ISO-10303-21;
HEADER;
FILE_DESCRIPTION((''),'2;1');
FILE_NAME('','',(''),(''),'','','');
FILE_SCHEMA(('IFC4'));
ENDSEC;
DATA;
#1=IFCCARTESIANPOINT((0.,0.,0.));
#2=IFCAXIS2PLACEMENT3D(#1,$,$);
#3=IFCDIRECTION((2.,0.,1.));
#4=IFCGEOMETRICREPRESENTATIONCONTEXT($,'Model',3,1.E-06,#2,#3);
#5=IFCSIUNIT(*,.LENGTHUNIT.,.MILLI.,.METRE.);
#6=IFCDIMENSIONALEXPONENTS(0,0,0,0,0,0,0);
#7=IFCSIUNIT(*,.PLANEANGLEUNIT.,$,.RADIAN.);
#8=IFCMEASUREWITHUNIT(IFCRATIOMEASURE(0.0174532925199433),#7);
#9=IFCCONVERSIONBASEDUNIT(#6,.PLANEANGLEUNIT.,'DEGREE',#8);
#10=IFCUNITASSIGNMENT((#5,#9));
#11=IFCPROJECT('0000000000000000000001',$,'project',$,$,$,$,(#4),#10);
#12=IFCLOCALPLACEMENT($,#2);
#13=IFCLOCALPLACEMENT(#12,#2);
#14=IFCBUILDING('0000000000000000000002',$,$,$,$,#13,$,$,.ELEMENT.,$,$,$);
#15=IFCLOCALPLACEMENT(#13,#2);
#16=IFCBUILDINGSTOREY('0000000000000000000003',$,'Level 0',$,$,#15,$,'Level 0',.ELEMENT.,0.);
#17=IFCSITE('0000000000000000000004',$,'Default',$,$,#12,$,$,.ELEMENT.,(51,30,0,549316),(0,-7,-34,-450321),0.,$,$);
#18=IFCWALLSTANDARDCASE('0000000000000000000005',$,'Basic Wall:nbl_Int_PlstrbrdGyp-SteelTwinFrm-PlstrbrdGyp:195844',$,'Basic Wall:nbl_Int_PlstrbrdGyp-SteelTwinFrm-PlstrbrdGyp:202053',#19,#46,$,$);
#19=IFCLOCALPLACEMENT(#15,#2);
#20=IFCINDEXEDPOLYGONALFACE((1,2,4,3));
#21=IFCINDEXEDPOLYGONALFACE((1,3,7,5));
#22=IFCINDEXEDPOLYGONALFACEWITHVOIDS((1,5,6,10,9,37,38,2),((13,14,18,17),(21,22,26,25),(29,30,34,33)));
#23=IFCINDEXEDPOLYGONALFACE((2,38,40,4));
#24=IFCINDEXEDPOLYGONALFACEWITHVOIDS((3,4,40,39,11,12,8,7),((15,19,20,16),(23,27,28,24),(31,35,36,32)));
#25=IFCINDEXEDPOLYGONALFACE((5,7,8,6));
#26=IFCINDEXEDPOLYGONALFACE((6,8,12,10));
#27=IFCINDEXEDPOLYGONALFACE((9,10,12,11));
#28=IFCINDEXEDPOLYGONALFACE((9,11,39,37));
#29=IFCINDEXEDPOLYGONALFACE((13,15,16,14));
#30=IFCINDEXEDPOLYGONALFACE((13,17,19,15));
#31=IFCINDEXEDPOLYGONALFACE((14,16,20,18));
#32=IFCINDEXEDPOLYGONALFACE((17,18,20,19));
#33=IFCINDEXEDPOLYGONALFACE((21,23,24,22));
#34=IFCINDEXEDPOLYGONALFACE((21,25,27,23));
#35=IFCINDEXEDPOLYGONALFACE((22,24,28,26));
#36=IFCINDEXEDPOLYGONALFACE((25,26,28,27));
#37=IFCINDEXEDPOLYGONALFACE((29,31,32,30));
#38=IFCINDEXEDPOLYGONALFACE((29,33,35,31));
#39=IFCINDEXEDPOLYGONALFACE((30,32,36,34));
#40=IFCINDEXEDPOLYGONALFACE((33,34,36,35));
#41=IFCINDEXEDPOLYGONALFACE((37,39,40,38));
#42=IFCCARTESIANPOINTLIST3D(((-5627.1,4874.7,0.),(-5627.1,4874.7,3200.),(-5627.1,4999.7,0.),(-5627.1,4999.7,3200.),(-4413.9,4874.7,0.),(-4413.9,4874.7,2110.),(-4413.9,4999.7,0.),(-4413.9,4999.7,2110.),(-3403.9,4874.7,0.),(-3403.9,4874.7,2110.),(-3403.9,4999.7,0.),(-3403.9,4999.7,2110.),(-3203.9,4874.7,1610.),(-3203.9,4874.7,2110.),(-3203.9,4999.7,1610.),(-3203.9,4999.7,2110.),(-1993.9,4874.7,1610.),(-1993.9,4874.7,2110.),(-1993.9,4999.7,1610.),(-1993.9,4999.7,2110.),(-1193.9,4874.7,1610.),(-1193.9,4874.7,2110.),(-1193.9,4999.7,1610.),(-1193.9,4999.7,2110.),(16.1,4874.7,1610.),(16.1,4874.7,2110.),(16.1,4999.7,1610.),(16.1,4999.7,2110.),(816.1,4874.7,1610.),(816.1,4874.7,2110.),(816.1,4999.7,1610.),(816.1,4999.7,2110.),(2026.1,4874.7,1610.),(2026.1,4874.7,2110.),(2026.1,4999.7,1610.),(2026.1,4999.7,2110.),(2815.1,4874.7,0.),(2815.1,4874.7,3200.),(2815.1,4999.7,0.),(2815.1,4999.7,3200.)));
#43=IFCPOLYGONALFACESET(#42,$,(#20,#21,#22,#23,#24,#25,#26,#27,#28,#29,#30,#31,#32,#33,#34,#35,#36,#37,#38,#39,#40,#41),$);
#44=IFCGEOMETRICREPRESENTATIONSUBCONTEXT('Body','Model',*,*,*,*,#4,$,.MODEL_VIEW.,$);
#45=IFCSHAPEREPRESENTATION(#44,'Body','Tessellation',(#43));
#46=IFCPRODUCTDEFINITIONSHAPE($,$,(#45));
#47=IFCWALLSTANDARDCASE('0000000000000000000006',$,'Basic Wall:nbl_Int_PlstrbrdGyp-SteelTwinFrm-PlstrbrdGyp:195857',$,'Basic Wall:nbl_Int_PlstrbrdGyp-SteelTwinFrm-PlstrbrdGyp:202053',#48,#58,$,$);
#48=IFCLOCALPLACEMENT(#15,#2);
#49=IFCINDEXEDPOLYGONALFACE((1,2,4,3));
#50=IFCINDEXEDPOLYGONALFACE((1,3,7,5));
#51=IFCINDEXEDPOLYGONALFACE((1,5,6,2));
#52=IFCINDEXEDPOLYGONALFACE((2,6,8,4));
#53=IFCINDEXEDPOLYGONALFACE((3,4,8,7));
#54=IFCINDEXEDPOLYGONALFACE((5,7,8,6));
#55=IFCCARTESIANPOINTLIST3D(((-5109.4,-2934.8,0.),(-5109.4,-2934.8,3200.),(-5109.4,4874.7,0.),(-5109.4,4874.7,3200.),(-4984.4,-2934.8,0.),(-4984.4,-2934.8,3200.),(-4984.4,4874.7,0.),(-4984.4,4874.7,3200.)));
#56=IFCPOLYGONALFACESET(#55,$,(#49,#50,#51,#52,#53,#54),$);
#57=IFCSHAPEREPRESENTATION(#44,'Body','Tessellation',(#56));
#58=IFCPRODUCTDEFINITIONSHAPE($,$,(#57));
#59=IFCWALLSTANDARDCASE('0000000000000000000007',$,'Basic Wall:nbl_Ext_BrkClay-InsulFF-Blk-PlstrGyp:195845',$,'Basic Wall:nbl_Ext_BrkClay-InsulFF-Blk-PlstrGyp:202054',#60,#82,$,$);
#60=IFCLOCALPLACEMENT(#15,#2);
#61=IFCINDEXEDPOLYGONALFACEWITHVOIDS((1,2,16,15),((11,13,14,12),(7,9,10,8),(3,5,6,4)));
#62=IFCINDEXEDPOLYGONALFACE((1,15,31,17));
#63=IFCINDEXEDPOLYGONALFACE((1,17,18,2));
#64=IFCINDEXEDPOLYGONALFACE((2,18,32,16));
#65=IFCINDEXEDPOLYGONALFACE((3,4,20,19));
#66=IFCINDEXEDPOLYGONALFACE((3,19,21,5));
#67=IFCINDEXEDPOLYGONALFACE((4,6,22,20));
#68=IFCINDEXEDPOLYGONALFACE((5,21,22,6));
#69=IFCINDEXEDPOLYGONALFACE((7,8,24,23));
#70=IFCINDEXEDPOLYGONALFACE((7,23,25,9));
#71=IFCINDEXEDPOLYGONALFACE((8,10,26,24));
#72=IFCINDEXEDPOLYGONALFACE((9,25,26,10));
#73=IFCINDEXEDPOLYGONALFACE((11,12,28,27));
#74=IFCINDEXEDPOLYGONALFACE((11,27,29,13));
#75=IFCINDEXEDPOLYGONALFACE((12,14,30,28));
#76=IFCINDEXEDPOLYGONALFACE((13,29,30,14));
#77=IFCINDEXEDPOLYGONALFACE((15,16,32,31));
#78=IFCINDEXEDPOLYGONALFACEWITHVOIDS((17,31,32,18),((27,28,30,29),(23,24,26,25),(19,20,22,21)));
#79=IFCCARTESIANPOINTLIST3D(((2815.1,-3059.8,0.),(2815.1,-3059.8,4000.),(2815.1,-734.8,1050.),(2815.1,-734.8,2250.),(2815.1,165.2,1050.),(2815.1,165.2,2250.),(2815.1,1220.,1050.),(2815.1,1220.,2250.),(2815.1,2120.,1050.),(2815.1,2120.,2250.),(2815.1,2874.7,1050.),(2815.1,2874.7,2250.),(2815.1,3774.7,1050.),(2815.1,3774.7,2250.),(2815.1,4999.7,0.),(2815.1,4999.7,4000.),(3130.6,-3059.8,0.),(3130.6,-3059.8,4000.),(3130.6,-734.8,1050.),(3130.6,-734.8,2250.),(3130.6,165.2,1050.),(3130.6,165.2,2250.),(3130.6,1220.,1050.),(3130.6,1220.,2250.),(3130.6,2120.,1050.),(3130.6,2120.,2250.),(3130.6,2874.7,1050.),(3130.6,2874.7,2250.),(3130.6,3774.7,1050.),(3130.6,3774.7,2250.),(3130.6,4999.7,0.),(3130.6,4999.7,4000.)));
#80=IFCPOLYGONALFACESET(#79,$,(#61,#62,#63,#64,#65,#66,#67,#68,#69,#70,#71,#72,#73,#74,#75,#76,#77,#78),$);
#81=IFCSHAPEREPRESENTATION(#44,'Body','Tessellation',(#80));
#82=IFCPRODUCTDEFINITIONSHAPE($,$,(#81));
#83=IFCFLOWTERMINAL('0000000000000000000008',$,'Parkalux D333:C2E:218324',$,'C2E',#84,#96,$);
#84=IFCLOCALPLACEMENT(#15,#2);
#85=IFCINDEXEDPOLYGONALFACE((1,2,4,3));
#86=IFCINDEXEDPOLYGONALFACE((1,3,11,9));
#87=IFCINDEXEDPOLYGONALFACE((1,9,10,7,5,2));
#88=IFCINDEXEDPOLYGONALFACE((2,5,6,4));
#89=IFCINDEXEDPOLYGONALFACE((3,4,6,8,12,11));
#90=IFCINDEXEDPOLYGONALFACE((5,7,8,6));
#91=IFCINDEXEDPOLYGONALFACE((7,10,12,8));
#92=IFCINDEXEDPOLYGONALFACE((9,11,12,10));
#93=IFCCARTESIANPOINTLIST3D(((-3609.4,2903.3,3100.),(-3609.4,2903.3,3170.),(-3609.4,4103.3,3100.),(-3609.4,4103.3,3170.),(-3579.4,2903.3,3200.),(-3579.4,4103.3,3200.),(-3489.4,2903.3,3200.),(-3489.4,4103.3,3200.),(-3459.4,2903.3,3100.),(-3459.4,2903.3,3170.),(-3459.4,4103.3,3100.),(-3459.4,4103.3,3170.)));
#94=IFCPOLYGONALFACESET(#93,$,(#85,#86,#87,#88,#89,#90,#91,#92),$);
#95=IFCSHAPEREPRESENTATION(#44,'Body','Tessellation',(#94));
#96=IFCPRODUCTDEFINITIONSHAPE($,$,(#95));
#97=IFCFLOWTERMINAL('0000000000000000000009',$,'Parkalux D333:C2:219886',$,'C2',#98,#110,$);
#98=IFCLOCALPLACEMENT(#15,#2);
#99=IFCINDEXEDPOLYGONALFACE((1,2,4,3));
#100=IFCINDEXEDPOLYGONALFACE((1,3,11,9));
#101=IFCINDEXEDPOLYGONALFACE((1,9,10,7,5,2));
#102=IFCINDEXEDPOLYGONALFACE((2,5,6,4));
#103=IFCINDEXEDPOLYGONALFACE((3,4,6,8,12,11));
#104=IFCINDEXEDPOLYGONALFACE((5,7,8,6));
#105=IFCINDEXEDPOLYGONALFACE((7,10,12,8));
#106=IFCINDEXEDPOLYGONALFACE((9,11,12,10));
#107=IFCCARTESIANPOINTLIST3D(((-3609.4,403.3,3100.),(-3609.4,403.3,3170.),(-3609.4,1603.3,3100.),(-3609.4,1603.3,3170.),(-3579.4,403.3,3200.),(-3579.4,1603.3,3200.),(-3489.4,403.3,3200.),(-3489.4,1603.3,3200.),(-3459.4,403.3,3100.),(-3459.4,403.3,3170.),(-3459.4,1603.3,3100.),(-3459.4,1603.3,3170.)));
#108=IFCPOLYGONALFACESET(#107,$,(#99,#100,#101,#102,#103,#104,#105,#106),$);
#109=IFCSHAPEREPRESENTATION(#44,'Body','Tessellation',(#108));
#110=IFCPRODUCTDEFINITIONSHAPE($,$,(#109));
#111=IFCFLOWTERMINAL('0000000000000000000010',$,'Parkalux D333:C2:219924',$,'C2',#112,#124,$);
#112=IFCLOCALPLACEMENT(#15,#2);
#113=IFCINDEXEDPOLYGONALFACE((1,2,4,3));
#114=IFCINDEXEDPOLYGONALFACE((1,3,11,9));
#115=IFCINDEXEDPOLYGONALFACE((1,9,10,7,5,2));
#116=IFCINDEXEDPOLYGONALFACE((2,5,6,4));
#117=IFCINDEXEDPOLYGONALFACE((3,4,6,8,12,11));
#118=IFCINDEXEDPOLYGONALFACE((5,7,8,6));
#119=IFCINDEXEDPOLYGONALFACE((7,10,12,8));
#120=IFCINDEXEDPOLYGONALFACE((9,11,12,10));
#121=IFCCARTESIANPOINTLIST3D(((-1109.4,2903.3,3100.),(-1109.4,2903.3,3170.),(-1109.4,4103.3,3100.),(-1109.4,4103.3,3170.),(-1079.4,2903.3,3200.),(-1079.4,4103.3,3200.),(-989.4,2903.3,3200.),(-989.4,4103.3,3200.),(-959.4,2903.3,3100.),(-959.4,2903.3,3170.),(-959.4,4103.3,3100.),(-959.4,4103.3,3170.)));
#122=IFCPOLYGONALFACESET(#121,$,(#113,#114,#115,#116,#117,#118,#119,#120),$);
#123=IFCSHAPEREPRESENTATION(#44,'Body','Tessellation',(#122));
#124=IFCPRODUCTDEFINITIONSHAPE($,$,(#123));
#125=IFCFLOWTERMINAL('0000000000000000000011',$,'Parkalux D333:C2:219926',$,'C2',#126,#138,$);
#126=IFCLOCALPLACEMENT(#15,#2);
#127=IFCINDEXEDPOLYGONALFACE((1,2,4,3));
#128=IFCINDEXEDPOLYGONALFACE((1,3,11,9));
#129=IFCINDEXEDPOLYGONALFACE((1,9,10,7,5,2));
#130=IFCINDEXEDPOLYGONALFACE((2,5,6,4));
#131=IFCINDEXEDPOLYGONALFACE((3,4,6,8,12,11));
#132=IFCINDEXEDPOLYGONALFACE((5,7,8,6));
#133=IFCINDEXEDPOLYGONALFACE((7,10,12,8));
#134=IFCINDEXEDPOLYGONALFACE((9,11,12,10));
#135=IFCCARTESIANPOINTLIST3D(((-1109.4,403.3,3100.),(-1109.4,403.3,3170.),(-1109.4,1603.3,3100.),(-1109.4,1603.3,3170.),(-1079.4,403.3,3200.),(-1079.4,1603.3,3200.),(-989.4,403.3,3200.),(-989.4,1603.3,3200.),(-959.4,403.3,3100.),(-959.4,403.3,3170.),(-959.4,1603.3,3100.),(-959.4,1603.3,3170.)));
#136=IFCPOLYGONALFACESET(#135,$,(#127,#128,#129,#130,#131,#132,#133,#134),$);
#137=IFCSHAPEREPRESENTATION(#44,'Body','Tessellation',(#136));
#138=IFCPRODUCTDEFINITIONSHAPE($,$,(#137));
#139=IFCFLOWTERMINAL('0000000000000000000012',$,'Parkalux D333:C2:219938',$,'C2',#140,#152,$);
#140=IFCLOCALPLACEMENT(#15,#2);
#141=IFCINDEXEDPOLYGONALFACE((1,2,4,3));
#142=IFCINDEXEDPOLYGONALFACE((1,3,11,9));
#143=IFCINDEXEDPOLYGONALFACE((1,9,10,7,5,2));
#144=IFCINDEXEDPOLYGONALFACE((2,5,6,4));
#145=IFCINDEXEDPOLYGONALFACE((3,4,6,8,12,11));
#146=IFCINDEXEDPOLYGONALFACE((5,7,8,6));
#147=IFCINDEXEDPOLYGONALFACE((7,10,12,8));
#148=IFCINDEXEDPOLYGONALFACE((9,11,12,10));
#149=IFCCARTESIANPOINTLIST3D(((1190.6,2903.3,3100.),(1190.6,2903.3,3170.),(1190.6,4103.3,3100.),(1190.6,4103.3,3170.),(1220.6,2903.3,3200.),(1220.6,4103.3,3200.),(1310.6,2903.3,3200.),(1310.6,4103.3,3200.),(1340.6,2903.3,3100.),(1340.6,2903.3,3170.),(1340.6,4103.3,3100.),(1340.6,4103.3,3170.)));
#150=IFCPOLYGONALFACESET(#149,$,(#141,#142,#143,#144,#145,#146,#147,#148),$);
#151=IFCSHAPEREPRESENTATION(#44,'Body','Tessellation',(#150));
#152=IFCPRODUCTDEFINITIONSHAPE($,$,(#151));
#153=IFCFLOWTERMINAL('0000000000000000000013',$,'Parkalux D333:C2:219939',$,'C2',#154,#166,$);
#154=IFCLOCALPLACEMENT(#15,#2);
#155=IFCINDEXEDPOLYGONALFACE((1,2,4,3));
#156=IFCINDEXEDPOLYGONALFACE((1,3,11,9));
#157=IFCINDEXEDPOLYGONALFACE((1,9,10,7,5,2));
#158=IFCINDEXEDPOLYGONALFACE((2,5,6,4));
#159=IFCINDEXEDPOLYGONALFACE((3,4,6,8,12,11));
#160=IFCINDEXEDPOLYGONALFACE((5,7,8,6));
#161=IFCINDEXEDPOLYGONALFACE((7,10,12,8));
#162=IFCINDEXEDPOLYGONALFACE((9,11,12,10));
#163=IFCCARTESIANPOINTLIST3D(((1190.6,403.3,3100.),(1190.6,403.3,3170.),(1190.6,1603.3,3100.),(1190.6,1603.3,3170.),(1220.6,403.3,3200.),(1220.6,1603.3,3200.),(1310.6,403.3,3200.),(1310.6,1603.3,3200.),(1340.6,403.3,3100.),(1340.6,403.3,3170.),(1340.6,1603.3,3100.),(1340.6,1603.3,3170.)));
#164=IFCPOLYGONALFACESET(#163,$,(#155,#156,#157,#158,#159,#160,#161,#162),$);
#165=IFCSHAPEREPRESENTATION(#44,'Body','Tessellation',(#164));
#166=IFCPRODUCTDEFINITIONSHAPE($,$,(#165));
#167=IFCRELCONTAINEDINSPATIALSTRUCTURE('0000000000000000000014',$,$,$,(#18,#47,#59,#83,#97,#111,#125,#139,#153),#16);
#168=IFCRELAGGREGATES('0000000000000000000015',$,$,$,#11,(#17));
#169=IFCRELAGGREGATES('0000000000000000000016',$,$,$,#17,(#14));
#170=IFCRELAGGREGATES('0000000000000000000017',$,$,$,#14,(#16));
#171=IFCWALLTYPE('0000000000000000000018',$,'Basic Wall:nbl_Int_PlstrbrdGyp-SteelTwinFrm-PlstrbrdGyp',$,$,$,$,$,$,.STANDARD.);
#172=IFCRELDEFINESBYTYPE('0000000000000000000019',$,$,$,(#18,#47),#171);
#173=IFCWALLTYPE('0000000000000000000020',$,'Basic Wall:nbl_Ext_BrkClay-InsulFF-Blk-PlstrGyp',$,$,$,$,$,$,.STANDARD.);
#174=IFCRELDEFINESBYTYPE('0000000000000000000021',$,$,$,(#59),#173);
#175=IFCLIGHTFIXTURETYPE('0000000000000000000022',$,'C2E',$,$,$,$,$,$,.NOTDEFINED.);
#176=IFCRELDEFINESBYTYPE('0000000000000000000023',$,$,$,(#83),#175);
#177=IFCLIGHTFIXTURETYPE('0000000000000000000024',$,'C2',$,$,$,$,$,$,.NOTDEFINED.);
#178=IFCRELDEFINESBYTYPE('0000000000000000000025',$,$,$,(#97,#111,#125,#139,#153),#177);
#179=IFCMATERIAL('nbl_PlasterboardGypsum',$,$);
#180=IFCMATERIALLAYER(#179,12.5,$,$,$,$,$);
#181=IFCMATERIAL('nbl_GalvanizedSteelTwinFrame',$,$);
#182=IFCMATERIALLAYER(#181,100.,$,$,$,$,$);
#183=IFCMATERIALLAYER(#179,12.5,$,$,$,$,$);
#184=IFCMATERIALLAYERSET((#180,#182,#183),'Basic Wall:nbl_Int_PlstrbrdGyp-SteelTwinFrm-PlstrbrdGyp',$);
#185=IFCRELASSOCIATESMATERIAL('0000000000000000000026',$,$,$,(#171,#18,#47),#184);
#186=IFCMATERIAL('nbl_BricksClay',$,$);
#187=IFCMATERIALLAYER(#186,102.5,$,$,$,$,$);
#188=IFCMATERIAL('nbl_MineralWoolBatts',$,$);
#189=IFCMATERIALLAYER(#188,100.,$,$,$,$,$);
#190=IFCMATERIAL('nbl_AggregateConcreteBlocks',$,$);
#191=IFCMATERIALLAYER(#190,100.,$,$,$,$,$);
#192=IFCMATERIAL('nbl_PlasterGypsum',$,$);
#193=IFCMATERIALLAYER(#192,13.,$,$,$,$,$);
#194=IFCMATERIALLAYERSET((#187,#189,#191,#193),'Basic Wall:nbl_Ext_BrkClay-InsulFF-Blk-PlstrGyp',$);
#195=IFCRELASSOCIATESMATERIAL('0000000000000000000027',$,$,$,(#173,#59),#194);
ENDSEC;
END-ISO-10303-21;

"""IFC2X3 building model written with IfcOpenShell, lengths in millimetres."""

from ifc_helpers import new_model, entity, si_unit, converted_unit, direction, frame, frame_2d, origin, place, context, subcontext, project, spatial, polyline, rectangle, outline, extrude, source, transform, mapped, material, layer, layer_set, layer_usage, type_object, type_shapes, element, save


model = new_model("IFC2X3")

# Units and contexts
model_context = context("Model", 3, precision=1e-06, world=origin(), true_north=direction((2.0, 0.0, 1.0)))
body_context = subcontext(model_context, "Body", "Model", "MODEL_VIEW")
ifc_project = project(units=[si_unit("LENGTHUNIT", "METRE", prefix="MILLI"), converted_unit("PLANEANGLEUNIT", "DEGREE", entity("IfcRatioMeasure", 0.0174532925199433), si_unit("PLANEANGLEUNIT", "RADIAN"), dimensions=[0, 0, 0, 0, 0, 0, 0])], contexts=[model_context])

# Site, building, storey
site_placement = place(None, origin())
site = spatial("IfcSite", under=ifc_project, at=site_placement, Name="Default", CompositionType="ELEMENT", RefLatitude=(51, 30, 0, 549316), RefLongitude=(0, -7, -34, -450321), RefElevation=0.0)
building_placement = place(site_placement, origin())
building = spatial("IfcBuilding", under=site, at=building_placement, CompositionType="ELEMENT")
storey_placement = place(building_placement, origin())
storey = spatial("IfcBuildingStorey", under=building, at=storey_placement, Name="Level 0", LongName="Level 0", CompositionType="ELEMENT", Elevation=0.0)

# Wall, openings
ifc_material_1 = material(Name="nbl_PlasterboardGypsum")
ifc_layer_1 = layer(ifc_material_1, 12.5)
ifc_material_2 = material(Name="nbl_GalvanizedSteelTwinFrame")
ifc_layer_2 = layer(ifc_material_2, 100.0)
ifc_layer_3 = layer(ifc_material_1, 12.5)
ifc_layer_set_1 = layer_set([ifc_layer_1, ifc_layer_2, ifc_layer_3], Name="Basic Wall:nbl_Int_PlstrbrdGyp-SteelTwinFrm-PlstrbrdGyp")
ifc_layer_usage_1 = layer_usage(ifc_layer_set_1, "AXIS2", "NEGATIVE", 62.5)
wall_type_1 = type_object("IfcWallType", Name="Basic Wall:nbl_Int_PlstrbrdGyp-SteelTwinFrm-PlstrbrdGyp", PredefinedType="STANDARD", material=ifc_layer_set_1)
wall_1_placement = place(storey_placement, frame((-5627.1, 4937.2, 0.0)))
wall_1 = element("IfcWallStandardCase", 1, at=wall_1_placement, inside=storey, type_object=wall_type_1, material=ifc_layer_usage_1, Name="Basic Wall:nbl_Int_PlstrbrdGyp-SteelTwinFrm-PlstrbrdGyp:195844", ObjectType="Basic Wall:nbl_Int_PlstrbrdGyp-SteelTwinFrm-PlstrbrdGyp:202053", context=body_context, shape_type="SweptSolid", body=[
    extrude(rectangle(XDim=8442.2, YDim=125.0, at=frame_2d((4221.1, 0.0), x_axis=(-1.0, 0.0))), origin(), (0.0, 0.0, 1.0), 3200.0),
])
opening_1_placement = place(wall_1_placement, frame((1213.3, -62.5, 0.0)))
element("IfcOpeningElement", 2, at=opening_1_placement, cuts=wall_1, ObjectType="Opening", context=body_context, shape_type="SweptSolid", body=[
    extrude(rectangle(XDim=2110.0, YDim=1010.0, at=frame_2d((1055.0, 505.0), x_axis=(1.0, 0.0))), frame((0.0, 0.0, 0.0), z_axis=(0.0, 1.0, 0.0), x_axis=(0.0, 0.0, 1.0)), (0.0, 0.0, 1.0), 125.0),
])
opening_2_placement = place(wall_1_placement, frame((7653.2, 62.5, 1610.0)))
element("IfcOpeningElement", 3, at=opening_2_placement, cuts=wall_1, ObjectType="Opening", context=body_context, shape_type="SweptSolid", body=[
    extrude(rectangle(XDim=500.0, YDim=1210.0, at=frame_2d((250.0, 605.0), x_axis=(-1.0, 0.0))), frame((0.0, 0.0, 0.0), z_axis=(0.0, -1.0, 0.0), x_axis=(0.0, 0.0, 1.0)), (0.0, 0.0, 1.0), 125.0),
])
opening_3_placement = place(wall_1_placement, frame((5643.2, 62.5, 1610.0)))
element("IfcOpeningElement", 4, at=opening_3_placement, cuts=wall_1, ObjectType="Opening", context=body_context, shape_type="SweptSolid", body=[
    extrude(rectangle(XDim=500.0, YDim=1210.0, at=frame_2d((250.0, 605.0), x_axis=(-1.0, 0.0))), frame((0.0, 0.0, 0.0), z_axis=(0.0, -1.0, 0.0), x_axis=(0.0, 0.0, 1.0)), (0.0, 0.0, 1.0), 125.0),
])
opening_4_placement = place(wall_1_placement, frame((3633.2, 62.5, 1610.0)))
element("IfcOpeningElement", 5, at=opening_4_placement, cuts=wall_1, ObjectType="Opening", context=body_context, shape_type="SweptSolid", body=[
    extrude(rectangle(XDim=500.0, YDim=1210.0, at=frame_2d((250.0, 605.0), x_axis=(-1.0, 0.0))), frame((0.0, 0.0, 0.0), z_axis=(0.0, -1.0, 0.0), x_axis=(0.0, 0.0, 1.0)), (0.0, 0.0, 1.0), 125.0),
])

# Wall
ifc_layer_usage_2 = layer_usage(ifc_layer_set_1, "AXIS2", "NEGATIVE", 62.5)
wall_2_placement = place(storey_placement, frame((-5046.9, 4874.7, 0.0), z_axis=(0.0, 0.0, 1.0), x_axis=(0.0, -1.0, 0.0)))
element("IfcWallStandardCase", 6, at=wall_2_placement, inside=storey, type_object=wall_type_1, material=ifc_layer_usage_2, Name="Basic Wall:nbl_Int_PlstrbrdGyp-SteelTwinFrm-PlstrbrdGyp:195857", ObjectType="Basic Wall:nbl_Int_PlstrbrdGyp-SteelTwinFrm-PlstrbrdGyp:202053", context=body_context, shape_type="SweptSolid", body=[
    extrude(rectangle(XDim=7809.5, YDim=125.0, at=frame_2d((3904.8, 0.0), x_axis=(-1.0, 0.0))), origin(), (0.0, 0.0, 1.0), 3200.0),
])

# Wall, openings
ifc_material_3 = material(Name="nbl_BricksClay")
ifc_layer_4 = layer(ifc_material_3, 102.5)
ifc_material_4 = material(Name="nbl_MineralWoolBatts")
ifc_layer_5 = layer(ifc_material_4, 100.0)
ifc_material_5 = material(Name="nbl_AggregateConcreteBlocks")
ifc_layer_6 = layer(ifc_material_5, 100.0)
ifc_material_6 = material(Name="nbl_PlasterGypsum")
ifc_layer_7 = layer(ifc_material_6, 13.0)
ifc_layer_set_2 = layer_set([ifc_layer_4, ifc_layer_5, ifc_layer_6, ifc_layer_7], Name="Basic Wall:nbl_Ext_BrkClay-InsulFF-Blk-PlstrGyp")
ifc_layer_usage_3 = layer_usage(ifc_layer_set_2, "AXIS2", "NEGATIVE", 157.8)
wall_type_2 = type_object("IfcWallType", Name="Basic Wall:nbl_Ext_BrkClay-InsulFF-Blk-PlstrGyp", PredefinedType="STANDARD", material=ifc_layer_set_2)
wall_3_placement = place(storey_placement, frame((2972.9, 4999.7, 0.0), z_axis=(0.0, 0.0, 1.0), x_axis=(0.0, -1.0, 0.0)))
wall_3 = element("IfcWallStandardCase", 7, at=wall_3_placement, inside=storey, type_object=wall_type_2, material=ifc_layer_usage_3, Name="Basic Wall:nbl_Ext_BrkClay-InsulFF-Blk-PlstrGyp:195845", ObjectType="Basic Wall:nbl_Ext_BrkClay-InsulFF-Blk-PlstrGyp:202054", context=body_context, shape_type="SweptSolid", body=[
    extrude(rectangle(XDim=8059.5, YDim=315.5, at=frame_2d((4029.8, 0.0), x_axis=(-1.0, 0.0))), origin(), (0.0, 0.0, 1.0), 4000.0),
])
opening_5_placement = place(wall_3_placement, frame((1225.0, -157.8, 1050.0)))
element("IfcOpeningElement", 8, at=opening_5_placement, cuts=wall_3, ObjectType="Opening", context=body_context, shape_type="SweptSolid", body=[
    extrude(rectangle(XDim=1200.0, YDim=900.0, at=frame_2d((600.0, 450.0), x_axis=(-1.0, 0.0))), frame((0.0, 0.0, 0.0), z_axis=(0.0, 1.0, 0.0), x_axis=(0.0, 0.0, 1.0)), (0.0, 0.0, 1.0), 315.5),
])
opening_6_placement = place(wall_3_placement, frame((4834.5, -157.8, 1050.0)))
element("IfcOpeningElement", 9, at=opening_6_placement, cuts=wall_3, ObjectType="Opening", context=body_context, shape_type="SweptSolid", body=[
    extrude(rectangle(XDim=1200.0, YDim=900.0, at=frame_2d((600.0, 450.0), x_axis=(-1.0, 0.0))), frame((0.0, 0.0, 0.0), z_axis=(0.0, 1.0, 0.0), x_axis=(0.0, 0.0, 1.0)), (0.0, 0.0, 1.0), 315.5),
])
opening_7_placement = place(wall_3_placement, frame((2879.8, -157.8, 1050.0)))
element("IfcOpeningElement", 10, at=opening_7_placement, cuts=wall_3, ObjectType="Opening", context=body_context, shape_type="SweptSolid", body=[
    extrude(rectangle(XDim=1200.0, YDim=900.0, at=frame_2d((600.0, 450.0), x_axis=(-1.0, 0.0))), frame((0.0, 0.0, 0.0), z_axis=(0.0, 1.0, 0.0), x_axis=(0.0, 0.0, 1.0)), (0.0, 0.0, 1.0), 315.5),
])

# Flow terminals
light_fixture_type_1 = type_object("IfcLightFixtureType", Name="C2E", PredefinedType="NOTDEFINED")
shared_shape_1 = source(origin(), body_context, "Body", "SweptSolid", [
    extrude(outline(polyline([(-56.7, -75.0), (13.3, -75.0), (43.3, -45.0), (43.3, 45.0), (13.3, 75.0), (-56.7, 75.0), (-56.7, -75.0)])), frame((0.0, 75.0, 56.7), z_axis=(1.0, 0.0, 0.0), x_axis=(0.0, 0.0, 1.0)), (0.0, 0.0, 1.0), 1200.0),
])
type_shapes(light_fixture_type_1, [shared_shape_1])
flow_terminal_placement = place(storey_placement, frame((-3609.4, 4103.3, 3100.0), z_axis=(0.0, 0.0, 1.0), x_axis=(0.0, -1.0, 0.0)))
element("IfcFlowTerminal", 11, at=flow_terminal_placement, inside=storey, type_object=light_fixture_type_1, Name="Parkalux D333:C2E:218324", ObjectType="C2E", context=body_context, shape_type="MappedRepresentation", body=[
    mapped(shared_shape_1, transform((0.0, 0.0, 0.0), scale=1.0)),
])
light_fixture_type_2 = type_object("IfcLightFixtureType", Name="C2", PredefinedType="NOTDEFINED")
shared_shape_2 = source(origin(), body_context, "Body", "SweptSolid", [
    extrude(outline(polyline([(-56.7, -75.0), (13.3, -75.0), (43.3, -45.0), (43.3, 45.0), (13.3, 75.0), (-56.7, 75.0), (-56.7, -75.0)])), frame((0.0, 75.0, 56.7), z_axis=(1.0, 0.0, 0.0), x_axis=(0.0, 0.0, 1.0)), (0.0, 0.0, 1.0), 1200.0),
])
type_shapes(light_fixture_type_2, [shared_shape_2])
for number, where, z_axis, x_axis, name in (
    (12, (-3609.4, 1603.3, 3100.0), (0.0, 0.0, 1.0), (0.0, -1.0, 0.0), "Parkalux D333:C2:219886"),
    (13, (-1109.4, 4103.3, 3100.0), (0.0, 0.0, 1.0), (0.0, -1.0, 0.0), "Parkalux D333:C2:219924"),
    (14, (-1109.4, 1603.3, 3100.0), (0.0, 0.0, 1.0), (0.0, -1.0, 0.0), "Parkalux D333:C2:219926"),
    (15, (1190.6, 4103.3, 3100.0), (0.0, 0.0, 1.0), (0.0, -1.0, 0.0), "Parkalux D333:C2:219938"),
    (16, (1190.6, 1603.3, 3100.0), (0.0, 0.0, 1.0), (0.0, -1.0, 0.0), "Parkalux D333:C2:219939"),
):
    element("IfcFlowTerminal", number, at=place(storey_placement, frame(where, z_axis=z_axis, x_axis=x_axis)), inside=storey, type_object=light_fixture_type_2, Name=name, ObjectType="C2", context=body_context, shape_type="MappedRepresentation", body=[
        mapped(shared_shape_2, transform((0.0, 0.0, 0.0), scale=1.0)),
    ])

save(model, "model.ifc")
